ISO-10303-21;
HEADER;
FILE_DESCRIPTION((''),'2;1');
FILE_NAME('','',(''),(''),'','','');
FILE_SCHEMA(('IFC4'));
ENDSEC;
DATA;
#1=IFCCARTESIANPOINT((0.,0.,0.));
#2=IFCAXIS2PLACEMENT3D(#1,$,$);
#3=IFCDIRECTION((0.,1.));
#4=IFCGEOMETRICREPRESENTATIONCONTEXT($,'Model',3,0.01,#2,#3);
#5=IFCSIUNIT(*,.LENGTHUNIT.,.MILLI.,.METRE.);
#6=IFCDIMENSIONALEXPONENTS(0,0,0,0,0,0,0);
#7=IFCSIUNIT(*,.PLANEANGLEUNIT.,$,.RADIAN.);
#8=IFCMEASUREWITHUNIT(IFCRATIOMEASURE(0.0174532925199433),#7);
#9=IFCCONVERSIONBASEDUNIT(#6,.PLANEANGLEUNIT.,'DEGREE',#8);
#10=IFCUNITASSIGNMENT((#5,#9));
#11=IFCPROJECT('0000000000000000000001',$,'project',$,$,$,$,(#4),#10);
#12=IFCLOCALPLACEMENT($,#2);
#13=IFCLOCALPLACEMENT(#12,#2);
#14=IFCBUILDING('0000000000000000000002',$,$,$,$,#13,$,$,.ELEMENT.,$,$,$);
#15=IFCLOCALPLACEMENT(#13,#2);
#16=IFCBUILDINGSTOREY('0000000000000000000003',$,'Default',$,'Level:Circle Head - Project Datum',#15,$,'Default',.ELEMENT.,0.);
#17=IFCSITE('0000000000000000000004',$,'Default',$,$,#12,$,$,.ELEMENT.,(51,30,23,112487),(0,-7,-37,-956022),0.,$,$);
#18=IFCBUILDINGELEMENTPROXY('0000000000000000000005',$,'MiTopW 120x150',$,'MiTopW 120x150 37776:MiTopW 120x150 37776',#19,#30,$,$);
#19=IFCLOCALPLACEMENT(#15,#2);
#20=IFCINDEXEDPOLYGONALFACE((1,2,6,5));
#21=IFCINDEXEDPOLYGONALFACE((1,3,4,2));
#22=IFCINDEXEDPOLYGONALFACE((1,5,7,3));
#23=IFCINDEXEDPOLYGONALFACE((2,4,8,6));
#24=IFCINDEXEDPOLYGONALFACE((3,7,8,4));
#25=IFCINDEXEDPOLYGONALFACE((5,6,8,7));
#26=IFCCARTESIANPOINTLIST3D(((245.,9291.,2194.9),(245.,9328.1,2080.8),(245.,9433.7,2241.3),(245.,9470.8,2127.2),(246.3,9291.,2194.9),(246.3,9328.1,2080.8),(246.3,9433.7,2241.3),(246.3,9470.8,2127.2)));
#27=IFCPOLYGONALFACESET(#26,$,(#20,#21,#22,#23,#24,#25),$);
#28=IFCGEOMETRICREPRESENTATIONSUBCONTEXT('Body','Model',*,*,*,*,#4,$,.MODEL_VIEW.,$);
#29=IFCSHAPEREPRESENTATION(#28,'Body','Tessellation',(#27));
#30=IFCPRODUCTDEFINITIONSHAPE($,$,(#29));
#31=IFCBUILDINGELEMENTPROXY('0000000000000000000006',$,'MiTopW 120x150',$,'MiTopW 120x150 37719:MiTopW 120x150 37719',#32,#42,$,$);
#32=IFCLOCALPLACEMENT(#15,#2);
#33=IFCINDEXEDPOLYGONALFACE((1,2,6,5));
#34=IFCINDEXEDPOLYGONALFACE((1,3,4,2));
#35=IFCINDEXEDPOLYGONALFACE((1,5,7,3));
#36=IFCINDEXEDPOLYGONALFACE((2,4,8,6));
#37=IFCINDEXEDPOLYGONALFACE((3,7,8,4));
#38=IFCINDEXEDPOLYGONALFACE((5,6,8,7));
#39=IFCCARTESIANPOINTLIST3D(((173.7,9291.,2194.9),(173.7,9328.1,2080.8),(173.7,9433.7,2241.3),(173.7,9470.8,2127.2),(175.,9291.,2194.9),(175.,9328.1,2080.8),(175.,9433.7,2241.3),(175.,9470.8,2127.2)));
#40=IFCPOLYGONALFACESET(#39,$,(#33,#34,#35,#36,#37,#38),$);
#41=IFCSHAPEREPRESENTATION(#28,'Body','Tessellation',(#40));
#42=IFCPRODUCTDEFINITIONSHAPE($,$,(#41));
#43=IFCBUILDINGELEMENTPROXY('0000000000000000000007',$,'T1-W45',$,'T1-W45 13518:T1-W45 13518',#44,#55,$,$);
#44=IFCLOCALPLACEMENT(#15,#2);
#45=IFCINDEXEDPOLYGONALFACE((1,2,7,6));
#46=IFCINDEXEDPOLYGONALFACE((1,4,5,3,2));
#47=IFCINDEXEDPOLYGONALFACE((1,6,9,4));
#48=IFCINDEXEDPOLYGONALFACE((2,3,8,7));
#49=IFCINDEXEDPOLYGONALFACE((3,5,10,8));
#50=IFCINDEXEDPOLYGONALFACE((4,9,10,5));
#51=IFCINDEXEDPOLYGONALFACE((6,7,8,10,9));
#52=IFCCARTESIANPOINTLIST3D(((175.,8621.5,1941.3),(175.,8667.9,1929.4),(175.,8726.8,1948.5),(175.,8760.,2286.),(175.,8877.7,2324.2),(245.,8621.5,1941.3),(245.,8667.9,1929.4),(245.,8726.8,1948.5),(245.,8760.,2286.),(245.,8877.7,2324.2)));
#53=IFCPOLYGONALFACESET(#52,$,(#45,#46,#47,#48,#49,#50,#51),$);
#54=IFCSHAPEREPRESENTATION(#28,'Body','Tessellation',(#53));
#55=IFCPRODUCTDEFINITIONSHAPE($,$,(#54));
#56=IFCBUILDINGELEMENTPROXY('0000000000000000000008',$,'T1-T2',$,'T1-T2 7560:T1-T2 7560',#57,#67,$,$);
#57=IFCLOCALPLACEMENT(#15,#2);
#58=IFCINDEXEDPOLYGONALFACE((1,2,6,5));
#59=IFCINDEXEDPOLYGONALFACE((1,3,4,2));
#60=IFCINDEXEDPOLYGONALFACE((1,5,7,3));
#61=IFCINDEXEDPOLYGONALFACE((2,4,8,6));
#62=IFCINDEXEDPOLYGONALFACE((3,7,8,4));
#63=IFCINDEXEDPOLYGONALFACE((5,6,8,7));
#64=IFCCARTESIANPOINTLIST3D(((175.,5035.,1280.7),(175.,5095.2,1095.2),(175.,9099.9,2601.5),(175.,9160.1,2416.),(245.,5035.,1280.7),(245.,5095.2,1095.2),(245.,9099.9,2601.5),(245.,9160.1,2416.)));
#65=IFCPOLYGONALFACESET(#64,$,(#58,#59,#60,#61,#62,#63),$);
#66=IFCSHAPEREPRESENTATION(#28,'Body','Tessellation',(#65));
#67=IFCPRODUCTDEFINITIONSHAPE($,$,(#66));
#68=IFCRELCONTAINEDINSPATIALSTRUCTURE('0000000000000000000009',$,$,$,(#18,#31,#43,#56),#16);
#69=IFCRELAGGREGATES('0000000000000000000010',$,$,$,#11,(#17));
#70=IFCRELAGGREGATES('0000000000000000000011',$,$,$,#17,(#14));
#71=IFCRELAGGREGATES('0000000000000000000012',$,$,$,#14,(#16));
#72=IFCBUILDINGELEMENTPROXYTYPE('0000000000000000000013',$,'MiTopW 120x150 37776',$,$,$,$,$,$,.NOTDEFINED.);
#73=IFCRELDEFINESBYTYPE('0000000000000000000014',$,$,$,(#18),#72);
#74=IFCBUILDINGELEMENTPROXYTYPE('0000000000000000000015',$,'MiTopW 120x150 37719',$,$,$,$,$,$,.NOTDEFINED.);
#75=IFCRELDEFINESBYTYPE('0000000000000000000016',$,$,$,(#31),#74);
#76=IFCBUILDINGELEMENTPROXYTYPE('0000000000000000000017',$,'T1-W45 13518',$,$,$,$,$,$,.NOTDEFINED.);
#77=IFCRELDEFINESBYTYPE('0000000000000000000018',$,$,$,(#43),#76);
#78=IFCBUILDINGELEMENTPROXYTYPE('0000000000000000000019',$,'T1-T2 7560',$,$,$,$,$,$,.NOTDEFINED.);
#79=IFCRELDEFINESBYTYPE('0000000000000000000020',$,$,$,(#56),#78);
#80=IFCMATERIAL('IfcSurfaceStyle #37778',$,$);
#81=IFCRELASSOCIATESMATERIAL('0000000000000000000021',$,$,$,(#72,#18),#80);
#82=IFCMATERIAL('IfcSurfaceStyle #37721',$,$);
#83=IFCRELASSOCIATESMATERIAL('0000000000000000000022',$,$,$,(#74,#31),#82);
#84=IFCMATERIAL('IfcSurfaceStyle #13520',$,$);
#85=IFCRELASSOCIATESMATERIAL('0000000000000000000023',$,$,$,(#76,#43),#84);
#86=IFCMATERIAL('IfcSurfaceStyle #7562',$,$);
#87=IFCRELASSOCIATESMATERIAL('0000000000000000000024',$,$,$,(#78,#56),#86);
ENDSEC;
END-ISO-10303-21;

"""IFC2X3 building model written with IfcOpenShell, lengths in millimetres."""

from ifc_helpers import new_model, entity, si_unit, converted_unit, direction, frame, origin, place, context, subcontext, project, spatial, polyline, outline, extrude, source, transform, mapped, material, type_object, type_shapes, element, save


model = new_model("IFC2X3")

# Units and contexts
model_context = context("Model", 3, precision=0.01, world=origin(), true_north=direction((0.0, 1.0)))
body_context = subcontext(model_context, "Body", "Model", "MODEL_VIEW")
ifc_project = project(units=[si_unit("LENGTHUNIT", "METRE", prefix="MILLI"), converted_unit("PLANEANGLEUNIT", "DEGREE", entity("IfcRatioMeasure", 0.0174532925199433), si_unit("PLANEANGLEUNIT", "RADIAN"), dimensions=[0, 0, 0, 0, 0, 0, 0])], contexts=[model_context])

# Site, building, storey
site_placement = place(None, origin())
site = spatial("IfcSite", under=ifc_project, at=site_placement, Name="Default", CompositionType="ELEMENT", RefLatitude=(51, 30, 23, 112487), RefLongitude=(0, -7, -37, -956022), RefElevation=0.0)
building_placement = place(site_placement, origin())
building = spatial("IfcBuilding", under=site, at=building_placement, CompositionType="ELEMENT")
storey_placement = place(building_placement, origin())
storey = spatial("IfcBuildingStorey", under=building, at=storey_placement, Name="Default", ObjectType="Level:Circle Head - Project Datum", LongName="Default", CompositionType="ELEMENT", Elevation=0.0)

# Building element proxies
ifc_material_1 = material(Name="IfcSurfaceStyle #37778")
building_element_proxy_type_1 = type_object("IfcBuildingElementProxyType", Name="MiTopW 120x150 37776", PredefinedType="NOTDEFINED", material=ifc_material_1)
shared_shape_1 = source(origin(), body_context, "Body", "SweptSolid", [
    extrude(outline(polyline([(-75.0, -60.0), (75.0, -60.0), (75.0, 60.0), (-75.0, 60.0), (-75.0, -60.0)])), frame((75.0, 60.0, 0.0), z_axis=(0.0, 0.0, 1.0), x_axis=(-1.0, 0.0, 0.0)), (0.0, 0.0, 1.0), 1.3),
])
type_shapes(building_element_proxy_type_1, [shared_shape_1])
proxy_1_placement = place(building_placement, frame((246.3, 9291.0, 2194.9), z_axis=(-1.0, 0.0, 0.0), x_axis=(0.0, 0.951057, 0.309017)))
element("IfcBuildingElementProxy", 1, at=proxy_1_placement, inside=storey, type_object=building_element_proxy_type_1, material=ifc_material_1, Name="MiTopW 120x150", ObjectType="MiTopW 120x150 37776:MiTopW 120x150 37776", context=body_context, shape_type="MappedRepresentation", body=[
    mapped(shared_shape_1, transform((0.0, 0.0, 0.0), scale=1.0)),
])
ifc_material_2 = material(Name="IfcSurfaceStyle #37721")
building_element_proxy_type_2 = type_object("IfcBuildingElementProxyType", Name="MiTopW 120x150 37719", PredefinedType="NOTDEFINED", material=ifc_material_2)
shared_shape_2 = source(origin(), body_context, "Body", "SweptSolid", [
    extrude(outline(polyline([(-75.0, -60.0), (75.0, -60.0), (75.0, 60.0), (-75.0, 60.0), (-75.0, -60.0)])), frame((75.0, 60.0, 0.0), z_axis=(0.0, 0.0, 1.0), x_axis=(-1.0, 0.0, 0.0)), (0.0, 0.0, 1.0), 1.3),
])
type_shapes(building_element_proxy_type_2, [shared_shape_2])
proxy_2_placement = place(building_placement, frame((175.0, 9291.0, 2194.9), z_axis=(-1.0, 0.0, 0.0), x_axis=(0.0, 0.951057, 0.309017)))
element("IfcBuildingElementProxy", 2, at=proxy_2_placement, inside=storey, type_object=building_element_proxy_type_2, material=ifc_material_2, Name="MiTopW 120x150", ObjectType="MiTopW 120x150 37719:MiTopW 120x150 37719", context=body_context, shape_type="MappedRepresentation", body=[
    mapped(shared_shape_2, transform((0.0, 0.0, 0.0), scale=1.0)),
])
ifc_material_3 = material(Name="IfcSurfaceStyle #13520")
building_element_proxy_type_3 = type_object("IfcBuildingElementProxyType", Name="T1-W45 13518", PredefinedType="NOTDEFINED", material=ifc_material_3)
shared_shape_3 = source(origin(), body_context, "Body", "SweptSolid", [
    extrude(outline(polyline([(-276.0, -47.5), (129.0, -47.5), (168.7, 0.0), (174.9, 47.5), (-196.6, 47.5), (-276.0, -47.5)])), frame((174.9, 47.5, 0.0), z_axis=(0.0, 0.0, 1.0), x_axis=(-1.0, 0.0, 0.0)), (0.0, 0.0, 1.0), 70.0),
])
type_shapes(building_element_proxy_type_3, [shared_shape_3])
proxy_3_placement = place(building_placement, frame((245.0, 8621.5, 1941.3), z_axis=(-1.0, 0.0, 0.0), x_axis=(0.0, 0.372788, 0.927917)))
element("IfcBuildingElementProxy", 3, at=proxy_3_placement, inside=storey, type_object=building_element_proxy_type_3, material=ifc_material_3, Name="T1-W45", ObjectType="T1-W45 13518:T1-W45 13518", context=body_context, shape_type="MappedRepresentation", body=[
    mapped(shared_shape_3, transform((0.0, 0.0, 0.0), scale=1.0)),
])
ifc_material_4 = material(Name="IfcSurfaceStyle #7562")
building_element_proxy_type_4 = type_object("IfcBuildingElementProxyType", Name="T1-T2 7560", PredefinedType="NOTDEFINED", material=ifc_material_4)
shared_shape_4 = source(origin(), body_context, "Body", "SweptSolid", [
    extrude(outline(polyline([(-2137.0, -97.5), (2137.0, -97.5), (2137.0, 97.5), (-2137.0, 97.5), (-2137.0, -97.5)])), frame((2137.0, 97.5, 0.0), z_axis=(0.0, 0.0, 1.0), x_axis=(-1.0, 0.0, 0.0)), (0.0, 0.0, 1.0), 70.0),
])
type_shapes(building_element_proxy_type_4, [shared_shape_4])
proxy_4_placement = place(building_placement, frame((245.0, 9160.1, 2416.0), z_axis=(-1.0, 0.0, 0.0), x_axis=(0.0, -0.951057, -0.309017)))
element("IfcBuildingElementProxy", 4, at=proxy_4_placement, inside=storey, type_object=building_element_proxy_type_4, material=ifc_material_4, Name="T1-T2", ObjectType="T1-T2 7560:T1-T2 7560", context=body_context, shape_type="MappedRepresentation", body=[
    mapped(shared_shape_4, transform((0.0, 0.0, 0.0), scale=1.0)),
])

save(model, "model.ifc")
